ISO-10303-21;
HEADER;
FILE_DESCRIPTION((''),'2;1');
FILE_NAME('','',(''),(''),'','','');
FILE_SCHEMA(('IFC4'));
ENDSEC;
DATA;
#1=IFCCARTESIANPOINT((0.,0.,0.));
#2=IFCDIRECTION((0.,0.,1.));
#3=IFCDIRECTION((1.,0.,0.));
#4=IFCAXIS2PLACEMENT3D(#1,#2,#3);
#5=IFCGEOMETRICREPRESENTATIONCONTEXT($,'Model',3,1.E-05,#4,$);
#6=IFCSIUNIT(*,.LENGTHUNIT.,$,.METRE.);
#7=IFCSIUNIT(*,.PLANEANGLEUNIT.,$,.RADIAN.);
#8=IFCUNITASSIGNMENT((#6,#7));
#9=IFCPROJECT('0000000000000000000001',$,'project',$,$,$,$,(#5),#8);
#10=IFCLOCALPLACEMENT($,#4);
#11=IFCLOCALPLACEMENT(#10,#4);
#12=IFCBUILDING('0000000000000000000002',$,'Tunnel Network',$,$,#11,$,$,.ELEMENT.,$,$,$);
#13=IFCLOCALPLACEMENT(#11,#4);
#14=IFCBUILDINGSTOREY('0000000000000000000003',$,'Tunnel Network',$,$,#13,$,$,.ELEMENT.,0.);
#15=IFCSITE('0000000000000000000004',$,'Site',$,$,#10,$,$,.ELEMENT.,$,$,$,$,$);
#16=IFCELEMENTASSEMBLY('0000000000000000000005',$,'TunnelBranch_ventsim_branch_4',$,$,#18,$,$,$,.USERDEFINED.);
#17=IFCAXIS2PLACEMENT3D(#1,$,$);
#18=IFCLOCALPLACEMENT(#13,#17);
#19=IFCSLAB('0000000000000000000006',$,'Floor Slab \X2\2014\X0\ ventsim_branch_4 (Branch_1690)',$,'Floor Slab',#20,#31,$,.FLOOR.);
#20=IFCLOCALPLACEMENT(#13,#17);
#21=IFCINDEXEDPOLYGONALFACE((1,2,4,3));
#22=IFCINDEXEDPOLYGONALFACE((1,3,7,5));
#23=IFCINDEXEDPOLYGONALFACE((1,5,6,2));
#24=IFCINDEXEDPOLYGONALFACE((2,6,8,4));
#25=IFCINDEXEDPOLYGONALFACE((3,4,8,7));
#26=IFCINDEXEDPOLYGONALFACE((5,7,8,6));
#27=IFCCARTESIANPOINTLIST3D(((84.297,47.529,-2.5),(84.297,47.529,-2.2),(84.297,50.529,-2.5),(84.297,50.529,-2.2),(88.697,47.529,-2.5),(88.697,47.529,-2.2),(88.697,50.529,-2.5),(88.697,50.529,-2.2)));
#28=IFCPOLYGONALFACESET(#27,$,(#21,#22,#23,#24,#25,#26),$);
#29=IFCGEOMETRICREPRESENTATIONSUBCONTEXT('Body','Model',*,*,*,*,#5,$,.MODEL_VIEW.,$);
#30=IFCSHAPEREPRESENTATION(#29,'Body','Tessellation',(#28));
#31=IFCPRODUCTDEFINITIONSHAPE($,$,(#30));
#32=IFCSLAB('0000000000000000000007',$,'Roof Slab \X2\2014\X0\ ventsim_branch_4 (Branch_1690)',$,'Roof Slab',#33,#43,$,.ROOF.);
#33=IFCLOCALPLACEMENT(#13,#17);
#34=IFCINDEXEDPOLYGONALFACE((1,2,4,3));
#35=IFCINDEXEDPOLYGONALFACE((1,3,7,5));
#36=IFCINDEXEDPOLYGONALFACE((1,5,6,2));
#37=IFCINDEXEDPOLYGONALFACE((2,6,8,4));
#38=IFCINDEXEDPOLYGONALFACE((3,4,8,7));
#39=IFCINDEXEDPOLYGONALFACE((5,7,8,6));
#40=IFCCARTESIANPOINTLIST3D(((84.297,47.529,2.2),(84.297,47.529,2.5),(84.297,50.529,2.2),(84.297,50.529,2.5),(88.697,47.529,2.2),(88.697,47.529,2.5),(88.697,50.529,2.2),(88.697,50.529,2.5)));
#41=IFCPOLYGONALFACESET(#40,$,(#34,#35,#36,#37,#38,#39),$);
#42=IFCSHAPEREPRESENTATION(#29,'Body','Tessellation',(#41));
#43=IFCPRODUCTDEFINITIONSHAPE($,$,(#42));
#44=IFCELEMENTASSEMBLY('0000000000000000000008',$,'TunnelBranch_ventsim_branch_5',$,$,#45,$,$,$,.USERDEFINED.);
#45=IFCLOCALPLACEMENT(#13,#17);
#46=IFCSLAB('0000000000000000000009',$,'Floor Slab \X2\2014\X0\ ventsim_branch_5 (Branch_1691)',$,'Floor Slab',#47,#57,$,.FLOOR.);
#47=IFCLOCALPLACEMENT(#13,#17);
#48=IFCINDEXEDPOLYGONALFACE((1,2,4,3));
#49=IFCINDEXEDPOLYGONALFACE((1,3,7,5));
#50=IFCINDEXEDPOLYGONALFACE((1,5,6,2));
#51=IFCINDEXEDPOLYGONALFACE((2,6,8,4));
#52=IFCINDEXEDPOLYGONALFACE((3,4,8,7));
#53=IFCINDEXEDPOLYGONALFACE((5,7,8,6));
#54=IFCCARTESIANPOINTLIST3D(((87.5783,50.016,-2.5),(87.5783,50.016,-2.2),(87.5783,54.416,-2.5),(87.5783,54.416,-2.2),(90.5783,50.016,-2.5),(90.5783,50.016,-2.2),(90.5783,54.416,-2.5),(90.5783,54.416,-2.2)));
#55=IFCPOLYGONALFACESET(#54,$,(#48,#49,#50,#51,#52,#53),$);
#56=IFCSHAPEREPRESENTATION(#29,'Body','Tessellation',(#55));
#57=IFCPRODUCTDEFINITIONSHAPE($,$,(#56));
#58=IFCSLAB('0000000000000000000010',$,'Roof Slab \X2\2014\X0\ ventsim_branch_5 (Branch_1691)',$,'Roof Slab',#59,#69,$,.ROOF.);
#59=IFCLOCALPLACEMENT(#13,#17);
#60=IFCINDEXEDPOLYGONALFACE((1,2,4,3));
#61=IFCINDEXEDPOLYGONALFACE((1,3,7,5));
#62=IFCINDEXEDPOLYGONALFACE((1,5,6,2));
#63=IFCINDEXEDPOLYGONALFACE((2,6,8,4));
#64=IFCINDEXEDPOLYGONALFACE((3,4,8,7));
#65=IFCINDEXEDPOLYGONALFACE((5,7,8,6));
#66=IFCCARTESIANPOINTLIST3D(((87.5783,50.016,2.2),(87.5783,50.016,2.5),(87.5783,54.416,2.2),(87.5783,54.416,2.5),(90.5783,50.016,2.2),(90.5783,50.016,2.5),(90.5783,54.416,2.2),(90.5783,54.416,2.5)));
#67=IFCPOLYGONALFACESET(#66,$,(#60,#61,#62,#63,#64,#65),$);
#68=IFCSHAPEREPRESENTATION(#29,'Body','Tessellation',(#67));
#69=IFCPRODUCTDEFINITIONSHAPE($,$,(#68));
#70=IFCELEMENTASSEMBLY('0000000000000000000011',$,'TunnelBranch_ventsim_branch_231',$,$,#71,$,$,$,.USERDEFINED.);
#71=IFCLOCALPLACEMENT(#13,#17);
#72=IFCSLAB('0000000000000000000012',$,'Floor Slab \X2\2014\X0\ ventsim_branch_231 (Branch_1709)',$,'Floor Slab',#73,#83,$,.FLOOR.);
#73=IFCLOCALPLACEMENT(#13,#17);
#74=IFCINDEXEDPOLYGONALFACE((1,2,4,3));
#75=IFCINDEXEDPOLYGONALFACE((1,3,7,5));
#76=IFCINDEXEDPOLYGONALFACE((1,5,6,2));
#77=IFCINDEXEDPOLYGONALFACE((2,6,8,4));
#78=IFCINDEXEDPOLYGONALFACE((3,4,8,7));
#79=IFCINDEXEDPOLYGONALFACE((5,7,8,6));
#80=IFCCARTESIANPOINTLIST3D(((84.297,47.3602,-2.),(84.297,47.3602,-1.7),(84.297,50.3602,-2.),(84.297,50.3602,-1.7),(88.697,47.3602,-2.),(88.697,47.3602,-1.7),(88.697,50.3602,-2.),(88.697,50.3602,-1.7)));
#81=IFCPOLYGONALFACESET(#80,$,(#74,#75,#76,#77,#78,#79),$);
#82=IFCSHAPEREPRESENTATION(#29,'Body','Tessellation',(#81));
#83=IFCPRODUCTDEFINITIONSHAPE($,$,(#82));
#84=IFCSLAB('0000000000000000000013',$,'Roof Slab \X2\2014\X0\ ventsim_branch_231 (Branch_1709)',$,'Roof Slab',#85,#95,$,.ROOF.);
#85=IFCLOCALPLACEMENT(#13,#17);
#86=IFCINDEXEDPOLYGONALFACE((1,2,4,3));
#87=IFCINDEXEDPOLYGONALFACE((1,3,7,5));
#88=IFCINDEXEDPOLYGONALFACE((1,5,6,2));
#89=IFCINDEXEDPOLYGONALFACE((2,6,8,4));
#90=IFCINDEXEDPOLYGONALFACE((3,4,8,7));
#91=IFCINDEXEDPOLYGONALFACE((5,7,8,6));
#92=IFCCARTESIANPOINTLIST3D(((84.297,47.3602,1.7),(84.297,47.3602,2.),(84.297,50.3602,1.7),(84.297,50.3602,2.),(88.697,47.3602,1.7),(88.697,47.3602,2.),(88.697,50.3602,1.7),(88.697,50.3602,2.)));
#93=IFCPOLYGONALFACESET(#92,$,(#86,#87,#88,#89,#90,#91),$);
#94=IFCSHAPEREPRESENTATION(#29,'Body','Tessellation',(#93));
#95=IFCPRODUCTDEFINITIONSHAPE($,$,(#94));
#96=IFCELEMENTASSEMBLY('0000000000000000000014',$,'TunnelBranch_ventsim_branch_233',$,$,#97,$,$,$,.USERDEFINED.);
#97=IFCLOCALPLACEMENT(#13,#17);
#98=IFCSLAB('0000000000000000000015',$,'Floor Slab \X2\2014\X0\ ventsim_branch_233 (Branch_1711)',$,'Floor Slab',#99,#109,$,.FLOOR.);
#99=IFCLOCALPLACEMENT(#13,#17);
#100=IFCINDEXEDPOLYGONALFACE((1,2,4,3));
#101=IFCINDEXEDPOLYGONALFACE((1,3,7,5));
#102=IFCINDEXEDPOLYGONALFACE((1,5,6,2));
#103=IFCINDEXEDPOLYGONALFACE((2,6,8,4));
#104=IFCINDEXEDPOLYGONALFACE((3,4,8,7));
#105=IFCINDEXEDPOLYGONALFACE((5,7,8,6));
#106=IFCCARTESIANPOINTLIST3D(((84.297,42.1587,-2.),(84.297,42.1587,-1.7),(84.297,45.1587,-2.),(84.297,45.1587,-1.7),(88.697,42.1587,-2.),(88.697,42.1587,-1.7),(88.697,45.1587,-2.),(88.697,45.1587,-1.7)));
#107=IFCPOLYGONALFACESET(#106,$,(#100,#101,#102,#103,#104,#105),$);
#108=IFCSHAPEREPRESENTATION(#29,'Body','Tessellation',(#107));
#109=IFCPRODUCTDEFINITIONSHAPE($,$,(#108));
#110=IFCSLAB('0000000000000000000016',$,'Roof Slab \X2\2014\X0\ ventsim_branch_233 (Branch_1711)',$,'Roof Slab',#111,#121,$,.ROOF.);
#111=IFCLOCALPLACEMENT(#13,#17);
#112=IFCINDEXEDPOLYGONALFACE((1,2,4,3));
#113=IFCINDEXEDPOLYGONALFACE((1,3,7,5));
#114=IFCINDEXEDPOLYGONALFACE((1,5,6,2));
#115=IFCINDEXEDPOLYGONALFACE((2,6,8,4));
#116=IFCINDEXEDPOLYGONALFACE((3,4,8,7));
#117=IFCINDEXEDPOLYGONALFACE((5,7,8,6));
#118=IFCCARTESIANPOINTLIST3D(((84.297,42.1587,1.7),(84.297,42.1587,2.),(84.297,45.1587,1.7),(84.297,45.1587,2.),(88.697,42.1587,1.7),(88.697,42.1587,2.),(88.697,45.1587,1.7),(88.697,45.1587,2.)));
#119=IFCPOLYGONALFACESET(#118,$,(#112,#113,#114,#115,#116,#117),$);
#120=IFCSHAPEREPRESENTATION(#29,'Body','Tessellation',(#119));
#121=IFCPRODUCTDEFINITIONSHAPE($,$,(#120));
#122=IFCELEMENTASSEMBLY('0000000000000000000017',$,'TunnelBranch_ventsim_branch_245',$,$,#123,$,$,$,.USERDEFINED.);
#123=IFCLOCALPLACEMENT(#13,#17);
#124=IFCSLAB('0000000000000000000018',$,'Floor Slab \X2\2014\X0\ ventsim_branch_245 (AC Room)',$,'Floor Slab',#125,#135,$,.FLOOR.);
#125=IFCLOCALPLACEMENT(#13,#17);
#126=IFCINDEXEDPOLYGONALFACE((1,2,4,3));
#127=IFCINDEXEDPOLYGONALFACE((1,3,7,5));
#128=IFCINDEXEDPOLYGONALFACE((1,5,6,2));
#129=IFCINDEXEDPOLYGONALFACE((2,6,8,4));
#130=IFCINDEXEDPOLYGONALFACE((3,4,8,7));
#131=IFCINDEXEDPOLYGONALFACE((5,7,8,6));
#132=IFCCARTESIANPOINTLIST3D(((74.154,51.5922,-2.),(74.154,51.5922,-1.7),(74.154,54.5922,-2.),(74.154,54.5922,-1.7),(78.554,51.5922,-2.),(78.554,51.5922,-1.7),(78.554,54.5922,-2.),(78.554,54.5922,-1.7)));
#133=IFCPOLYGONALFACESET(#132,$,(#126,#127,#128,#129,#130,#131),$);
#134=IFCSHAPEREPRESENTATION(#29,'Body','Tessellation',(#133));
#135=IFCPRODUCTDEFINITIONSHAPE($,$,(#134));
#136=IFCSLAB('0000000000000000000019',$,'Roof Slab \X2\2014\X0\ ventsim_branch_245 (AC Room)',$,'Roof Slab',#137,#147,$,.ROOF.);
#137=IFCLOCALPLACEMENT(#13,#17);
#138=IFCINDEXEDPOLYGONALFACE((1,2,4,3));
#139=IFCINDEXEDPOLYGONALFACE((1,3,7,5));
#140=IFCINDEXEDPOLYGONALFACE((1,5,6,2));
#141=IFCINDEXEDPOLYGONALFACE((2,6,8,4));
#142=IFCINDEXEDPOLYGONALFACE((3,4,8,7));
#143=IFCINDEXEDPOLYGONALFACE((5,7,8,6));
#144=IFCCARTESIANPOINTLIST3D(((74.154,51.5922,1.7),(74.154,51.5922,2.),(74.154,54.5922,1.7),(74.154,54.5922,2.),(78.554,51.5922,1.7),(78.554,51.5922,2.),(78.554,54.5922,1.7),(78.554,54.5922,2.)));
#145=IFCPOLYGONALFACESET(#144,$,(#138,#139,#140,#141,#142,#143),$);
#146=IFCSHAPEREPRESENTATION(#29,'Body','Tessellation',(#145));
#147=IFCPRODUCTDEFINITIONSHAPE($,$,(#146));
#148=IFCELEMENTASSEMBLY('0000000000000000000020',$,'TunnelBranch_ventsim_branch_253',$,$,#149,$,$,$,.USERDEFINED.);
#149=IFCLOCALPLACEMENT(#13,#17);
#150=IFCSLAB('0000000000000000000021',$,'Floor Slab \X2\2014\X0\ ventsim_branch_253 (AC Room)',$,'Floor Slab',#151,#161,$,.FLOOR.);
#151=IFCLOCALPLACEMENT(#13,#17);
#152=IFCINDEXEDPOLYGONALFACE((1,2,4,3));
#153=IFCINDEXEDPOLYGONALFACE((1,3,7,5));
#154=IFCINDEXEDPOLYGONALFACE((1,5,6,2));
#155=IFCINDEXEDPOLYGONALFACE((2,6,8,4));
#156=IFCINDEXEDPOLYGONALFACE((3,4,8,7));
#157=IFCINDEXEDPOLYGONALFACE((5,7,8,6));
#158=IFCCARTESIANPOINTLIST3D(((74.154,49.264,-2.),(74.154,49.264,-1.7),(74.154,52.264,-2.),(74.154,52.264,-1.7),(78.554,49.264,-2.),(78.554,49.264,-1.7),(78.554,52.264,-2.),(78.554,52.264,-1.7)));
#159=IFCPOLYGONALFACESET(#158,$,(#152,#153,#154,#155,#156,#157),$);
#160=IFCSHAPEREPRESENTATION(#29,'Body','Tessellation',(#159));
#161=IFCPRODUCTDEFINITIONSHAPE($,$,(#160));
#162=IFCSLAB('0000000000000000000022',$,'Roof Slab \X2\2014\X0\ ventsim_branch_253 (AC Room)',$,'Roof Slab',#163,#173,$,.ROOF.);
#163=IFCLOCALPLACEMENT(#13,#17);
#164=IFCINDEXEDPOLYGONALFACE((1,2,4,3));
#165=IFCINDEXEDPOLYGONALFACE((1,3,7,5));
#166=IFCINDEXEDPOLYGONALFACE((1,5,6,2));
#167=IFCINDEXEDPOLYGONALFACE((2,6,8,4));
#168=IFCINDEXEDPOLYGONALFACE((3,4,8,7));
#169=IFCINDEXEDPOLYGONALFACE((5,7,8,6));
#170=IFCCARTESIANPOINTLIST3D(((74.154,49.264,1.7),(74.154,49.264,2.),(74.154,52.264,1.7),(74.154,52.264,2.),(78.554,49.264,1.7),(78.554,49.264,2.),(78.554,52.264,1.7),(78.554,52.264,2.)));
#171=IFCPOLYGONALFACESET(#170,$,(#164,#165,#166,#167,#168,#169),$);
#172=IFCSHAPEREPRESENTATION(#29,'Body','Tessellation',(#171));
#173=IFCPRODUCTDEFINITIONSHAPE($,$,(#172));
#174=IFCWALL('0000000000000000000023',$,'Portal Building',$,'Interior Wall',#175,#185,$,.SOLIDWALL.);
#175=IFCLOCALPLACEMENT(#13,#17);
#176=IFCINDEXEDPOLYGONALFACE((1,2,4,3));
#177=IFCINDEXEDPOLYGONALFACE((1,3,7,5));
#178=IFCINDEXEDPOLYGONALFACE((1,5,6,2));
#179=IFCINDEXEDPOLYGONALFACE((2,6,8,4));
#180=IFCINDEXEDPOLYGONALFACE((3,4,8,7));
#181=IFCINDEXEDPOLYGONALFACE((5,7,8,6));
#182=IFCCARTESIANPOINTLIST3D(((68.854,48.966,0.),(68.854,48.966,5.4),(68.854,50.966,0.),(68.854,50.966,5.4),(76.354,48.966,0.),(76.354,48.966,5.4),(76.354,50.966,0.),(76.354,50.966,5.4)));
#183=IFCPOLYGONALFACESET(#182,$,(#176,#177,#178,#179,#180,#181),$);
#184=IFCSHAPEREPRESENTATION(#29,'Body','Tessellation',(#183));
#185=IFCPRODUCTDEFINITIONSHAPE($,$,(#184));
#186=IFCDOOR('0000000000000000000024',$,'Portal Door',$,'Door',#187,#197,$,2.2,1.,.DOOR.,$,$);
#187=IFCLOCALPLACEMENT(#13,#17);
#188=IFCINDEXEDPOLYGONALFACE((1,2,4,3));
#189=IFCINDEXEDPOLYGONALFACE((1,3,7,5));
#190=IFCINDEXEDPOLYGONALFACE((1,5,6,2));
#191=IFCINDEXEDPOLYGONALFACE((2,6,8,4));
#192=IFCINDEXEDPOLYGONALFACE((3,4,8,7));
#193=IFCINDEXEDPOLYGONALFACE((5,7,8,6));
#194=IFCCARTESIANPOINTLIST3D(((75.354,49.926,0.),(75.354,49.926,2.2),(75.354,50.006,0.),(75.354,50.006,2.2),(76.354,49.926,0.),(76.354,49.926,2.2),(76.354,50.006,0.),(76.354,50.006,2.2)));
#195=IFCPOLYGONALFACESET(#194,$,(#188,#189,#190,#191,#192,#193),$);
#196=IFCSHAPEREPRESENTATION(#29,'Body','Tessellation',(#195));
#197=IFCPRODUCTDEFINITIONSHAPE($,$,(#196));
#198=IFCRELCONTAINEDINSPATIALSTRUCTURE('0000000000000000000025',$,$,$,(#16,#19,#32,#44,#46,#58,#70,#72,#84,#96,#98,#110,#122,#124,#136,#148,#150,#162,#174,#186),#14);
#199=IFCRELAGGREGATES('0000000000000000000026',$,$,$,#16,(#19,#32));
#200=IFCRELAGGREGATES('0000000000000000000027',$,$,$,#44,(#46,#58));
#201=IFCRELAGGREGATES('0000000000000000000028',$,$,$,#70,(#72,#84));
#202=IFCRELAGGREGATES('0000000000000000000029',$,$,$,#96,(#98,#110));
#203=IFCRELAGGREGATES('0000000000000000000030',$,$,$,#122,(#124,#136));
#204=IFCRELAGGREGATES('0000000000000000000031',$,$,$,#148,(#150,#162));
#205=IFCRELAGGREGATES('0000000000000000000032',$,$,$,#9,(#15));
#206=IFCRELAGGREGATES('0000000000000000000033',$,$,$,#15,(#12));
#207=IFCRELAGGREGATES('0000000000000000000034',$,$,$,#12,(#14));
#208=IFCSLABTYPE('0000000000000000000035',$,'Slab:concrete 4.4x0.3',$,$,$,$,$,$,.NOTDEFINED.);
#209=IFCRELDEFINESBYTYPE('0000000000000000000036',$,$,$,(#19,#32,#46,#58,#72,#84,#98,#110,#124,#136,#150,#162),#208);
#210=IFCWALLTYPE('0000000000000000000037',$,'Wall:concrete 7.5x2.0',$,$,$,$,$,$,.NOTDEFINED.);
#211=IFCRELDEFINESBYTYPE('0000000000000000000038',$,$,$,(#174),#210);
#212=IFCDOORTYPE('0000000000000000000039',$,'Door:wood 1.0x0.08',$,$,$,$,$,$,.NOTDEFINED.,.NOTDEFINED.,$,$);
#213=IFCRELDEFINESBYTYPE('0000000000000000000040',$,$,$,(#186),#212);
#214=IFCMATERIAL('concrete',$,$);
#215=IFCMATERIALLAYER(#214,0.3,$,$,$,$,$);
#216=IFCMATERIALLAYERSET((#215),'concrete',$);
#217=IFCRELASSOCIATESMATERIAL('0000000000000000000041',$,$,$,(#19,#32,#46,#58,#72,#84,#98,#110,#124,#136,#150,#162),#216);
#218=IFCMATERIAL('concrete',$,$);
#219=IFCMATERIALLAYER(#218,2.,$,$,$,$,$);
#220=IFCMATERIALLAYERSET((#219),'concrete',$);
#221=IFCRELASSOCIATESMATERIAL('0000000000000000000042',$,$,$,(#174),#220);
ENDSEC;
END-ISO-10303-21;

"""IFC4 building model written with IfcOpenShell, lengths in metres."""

from ifc_helpers import new_model, si_unit, frame, origin_with_axes, origin_2d_with_axis, place, context, subcontext, project, spatial, rectangle, extrude, material, layer, layer_set, layer_usage, type_object, element, aggregate, save


model = new_model("IFC4")

# Units and contexts
model_context = context("Model", 3, precision=1e-05, world=origin_with_axes())
body_context = subcontext(model_context, "Body", "Model", "MODEL_VIEW")
ifc_project = project(units=[si_unit("LENGTHUNIT", "METRE"), si_unit("PLANEANGLEUNIT", "RADIAN")], contexts=[model_context])

# Site, building, storey
site_placement = place(None, origin_with_axes())
site = spatial("IfcSite", under=ifc_project, at=site_placement, Name="Site", CompositionType="ELEMENT")
building_placement = place(site_placement, origin_with_axes())
building = spatial("IfcBuilding", under=site, at=building_placement, Name="Tunnel Network", CompositionType="ELEMENT")
storey_placement = place(building_placement, origin_with_axes())
storey = spatial("IfcBuildingStorey", under=building, at=storey_placement, Name="Tunnel Network", CompositionType="ELEMENT", Elevation=0.0)

# Element assemblies, slabs
assembly_1_placement = place(storey_placement, frame((84.147, 47.7701, 0.0), z_axis=(0.0, 1.0, 0.0), x_axis=(1.0, 0.0, 0.0)))
assembly_1 = element("IfcElementAssembly", 1, at=assembly_1_placement, inside=storey, Name="TunnelBranch_ventsim_branch_4", PredefinedType="USERDEFINED")
ifc_material_1 = material(Name="concrete")
ifc_layer_1 = layer(ifc_material_1, 0.3)
ifc_layer_set_1 = layer_set([ifc_layer_1], Name="concrete")
ifc_layer_usage_1 = layer_usage(ifc_layer_set_1, "AXIS3", "POSITIVE", 0.0)
slab_type = type_object("IfcSlabType", Name="Slab:concrete 4.4x0.3")
slab_1_placement = place(storey_placement, frame((86.497, 47.529, -2.35), z_axis=(0.0, 1.0, 0.0), x_axis=(1.0, 0.0, 0.0)))
slab_1 = element("IfcSlab", 2, at=slab_1_placement, inside=storey, type_object=slab_type, material=ifc_layer_usage_1, Name="Floor Slab — ventsim_branch_4 (Branch_1690)", ObjectType="Floor Slab", PredefinedType="FLOOR", context=body_context, shape_type="SweptSolid", body=[
    extrude(rectangle(XDim=4.4, YDim=0.3, at=origin_2d_with_axis()), origin_with_axes(), (0.0, 0.0, 1.0), 3.0),
])
ifc_layer_usage_2 = layer_usage(ifc_layer_set_1, "AXIS3", "POSITIVE", 0.0)
slab_2_placement = place(storey_placement, frame((86.497, 47.529, 2.35), z_axis=(0.0, 1.0, 0.0), x_axis=(1.0, 0.0, 0.0)))
slab_2 = element("IfcSlab", 3, at=slab_2_placement, inside=storey, type_object=slab_type, material=ifc_layer_usage_2, Name="Roof Slab — ventsim_branch_4 (Branch_1690)", ObjectType="Roof Slab", PredefinedType="ROOF", context=body_context, shape_type="SweptSolid", body=[
    extrude(rectangle(XDim=4.4, YDim=0.3, at=origin_2d_with_axis()), origin_with_axes(), (0.0, 0.0, 1.0), 3.0),
])
assembly_2_placement = place(storey_placement, frame((91.0006, 49.866, 0.0), z_axis=(-1.0, 0.0, 0.0), x_axis=(0.0, 1.0, 0.0)))
assembly_2 = element("IfcElementAssembly", 4, at=assembly_2_placement, inside=storey, Name="TunnelBranch_ventsim_branch_5", PredefinedType="USERDEFINED")
ifc_layer_usage_3 = layer_usage(ifc_layer_set_1, "AXIS3", "POSITIVE", 0.0)
slab_3_placement = place(storey_placement, frame((90.5783, 52.216, -2.35), z_axis=(-1.0, 0.0, 0.0), x_axis=(0.0, 1.0, 0.0)))
slab_3 = element("IfcSlab", 5, at=slab_3_placement, inside=storey, type_object=slab_type, material=ifc_layer_usage_3, Name="Floor Slab — ventsim_branch_5 (Branch_1691)", ObjectType="Floor Slab", PredefinedType="FLOOR", context=body_context, shape_type="SweptSolid", body=[
    extrude(rectangle(XDim=4.4, YDim=0.3, at=origin_2d_with_axis()), origin_with_axes(), (0.0, 0.0, 1.0), 3.0),
])
ifc_layer_usage_4 = layer_usage(ifc_layer_set_1, "AXIS3", "POSITIVE", 0.0)
slab_4_placement = place(storey_placement, frame((90.5783, 52.216, 2.35), z_axis=(-1.0, 0.0, 0.0), x_axis=(0.0, 1.0, 0.0)))
slab_4 = element("IfcSlab", 6, at=slab_4_placement, inside=storey, type_object=slab_type, material=ifc_layer_usage_4, Name="Roof Slab — ventsim_branch_5 (Branch_1691)", ObjectType="Roof Slab", PredefinedType="ROOF", context=body_context, shape_type="SweptSolid", body=[
    extrude(rectangle(XDim=4.4, YDim=0.3, at=origin_2d_with_axis()), origin_with_axes(), (0.0, 0.0, 1.0), 3.0),
])
assembly_3_placement = place(storey_placement, frame((84.147, 47.7701, 0.0), z_axis=(0.0, 1.0, 0.0), x_axis=(1.0, 0.0, 0.0)))
assembly_3 = element("IfcElementAssembly", 7, at=assembly_3_placement, inside=storey, Name="TunnelBranch_ventsim_branch_231", PredefinedType="USERDEFINED")
ifc_layer_usage_5 = layer_usage(ifc_layer_set_1, "AXIS3", "POSITIVE", 0.0)
slab_5_placement = place(storey_placement, frame((86.497, 47.3602, -1.85), z_axis=(0.0, 1.0, 0.0), x_axis=(1.0, 0.0, 0.0)))
slab_5 = element("IfcSlab", 8, at=slab_5_placement, inside=storey, type_object=slab_type, material=ifc_layer_usage_5, Name="Floor Slab — ventsim_branch_231 (Branch_1709)", ObjectType="Floor Slab", PredefinedType="FLOOR", context=body_context, shape_type="SweptSolid", body=[
    extrude(rectangle(XDim=4.4, YDim=0.3, at=origin_2d_with_axis()), origin_with_axes(), (0.0, 0.0, 1.0), 3.0),
])
ifc_layer_usage_6 = layer_usage(ifc_layer_set_1, "AXIS3", "POSITIVE", 0.0)
slab_6_placement = place(storey_placement, frame((86.497, 47.3602, 1.85), z_axis=(0.0, 1.0, 0.0), x_axis=(1.0, 0.0, 0.0)))
slab_6 = element("IfcSlab", 9, at=slab_6_placement, inside=storey, type_object=slab_type, material=ifc_layer_usage_6, Name="Roof Slab — ventsim_branch_231 (Branch_1709)", ObjectType="Roof Slab", PredefinedType="ROOF", context=body_context, shape_type="SweptSolid", body=[
    extrude(rectangle(XDim=4.4, YDim=0.3, at=origin_2d_with_axis()), origin_with_axes(), (0.0, 0.0, 1.0), 3.0),
])
assembly_4_placement = place(storey_placement, frame((84.147, 52.3609, 0.0), z_axis=(0.0, 1.0, 0.0), x_axis=(1.0, 0.0, 0.0)))
assembly_4 = element("IfcElementAssembly", 10, at=assembly_4_placement, inside=storey, Name="TunnelBranch_ventsim_branch_233", PredefinedType="USERDEFINED")
ifc_layer_usage_7 = layer_usage(ifc_layer_set_1, "AXIS3", "POSITIVE", 0.0)
slab_7_placement = place(storey_placement, frame((86.497, 42.1587, -1.85), z_axis=(0.0, 1.0, 0.0), x_axis=(1.0, 0.0, 0.0)))
slab_7 = element("IfcSlab", 11, at=slab_7_placement, inside=storey, type_object=slab_type, material=ifc_layer_usage_7, Name="Floor Slab — ventsim_branch_233 (Branch_1711)", ObjectType="Floor Slab", PredefinedType="FLOOR", context=body_context, shape_type="SweptSolid", body=[
    extrude(rectangle(XDim=4.4, YDim=0.3, at=origin_2d_with_axis()), origin_with_axes(), (0.0, 0.0, 1.0), 3.0),
])
ifc_layer_usage_8 = layer_usage(ifc_layer_set_1, "AXIS3", "POSITIVE", 0.0)
slab_8_placement = place(storey_placement, frame((86.497, 42.1587, 1.85), z_axis=(0.0, 1.0, 0.0), x_axis=(1.0, 0.0, 0.0)))
slab_8 = element("IfcSlab", 12, at=slab_8_placement, inside=storey, type_object=slab_type, material=ifc_layer_usage_8, Name="Roof Slab — ventsim_branch_233 (Branch_1711)", ObjectType="Roof Slab", PredefinedType="ROOF", context=body_context, shape_type="SweptSolid", body=[
    extrude(rectangle(XDim=4.4, YDim=0.3, at=origin_2d_with_axis()), origin_with_axes(), (0.0, 0.0, 1.0), 3.0),
])
assembly_5_placement = place(storey_placement, frame((74.004, 51.5922, 0.0), z_axis=(0.0, 1.0, 0.0), x_axis=(1.0, 0.0, 0.0)))
assembly_5 = element("IfcElementAssembly", 13, at=assembly_5_placement, inside=storey, Name="TunnelBranch_ventsim_branch_245", PredefinedType="USERDEFINED")
ifc_layer_usage_9 = layer_usage(ifc_layer_set_1, "AXIS3", "POSITIVE", 0.0)
slab_9_placement = place(storey_placement, frame((76.354, 51.5922, -1.85), z_axis=(0.0, 1.0, 0.0), x_axis=(1.0, 0.0, 0.0)))
slab_9 = element("IfcSlab", 14, at=slab_9_placement, inside=storey, type_object=slab_type, material=ifc_layer_usage_9, Name="Floor Slab — ventsim_branch_245 (AC Room)", ObjectType="Floor Slab", PredefinedType="FLOOR", context=body_context, shape_type="SweptSolid", body=[
    extrude(rectangle(XDim=4.4, YDim=0.3, at=origin_2d_with_axis()), origin_with_axes(), (0.0, 0.0, 1.0), 3.0),
])
ifc_layer_usage_10 = layer_usage(ifc_layer_set_1, "AXIS3", "POSITIVE", 0.0)
slab_10_placement = place(storey_placement, frame((76.354, 51.5922, 1.85), z_axis=(0.0, 1.0, 0.0), x_axis=(1.0, 0.0, 0.0)))
slab_10 = element("IfcSlab", 15, at=slab_10_placement, inside=storey, type_object=slab_type, material=ifc_layer_usage_10, Name="Roof Slab — ventsim_branch_245 (AC Room)", ObjectType="Roof Slab", PredefinedType="ROOF", context=body_context, shape_type="SweptSolid", body=[
    extrude(rectangle(XDim=4.4, YDim=0.3, at=origin_2d_with_axis()), origin_with_axes(), (0.0, 0.0, 1.0), 3.0),
])
assembly_6_placement = place(storey_placement, frame((74.004, 49.264, 0.0), z_axis=(0.0, 1.0, 0.0), x_axis=(1.0, 0.0, 0.0)))
assembly_6 = element("IfcElementAssembly", 16, at=assembly_6_placement, inside=storey, Name="TunnelBranch_ventsim_branch_253", PredefinedType="USERDEFINED")
ifc_layer_usage_11 = layer_usage(ifc_layer_set_1, "AXIS3", "POSITIVE", 0.0)
slab_11_placement = place(storey_placement, frame((76.354, 49.264, -1.85), z_axis=(0.0, 1.0, 0.0), x_axis=(1.0, 0.0, 0.0)))
slab_11 = element("IfcSlab", 17, at=slab_11_placement, inside=storey, type_object=slab_type, material=ifc_layer_usage_11, Name="Floor Slab — ventsim_branch_253 (AC Room)", ObjectType="Floor Slab", PredefinedType="FLOOR", context=body_context, shape_type="SweptSolid", body=[
    extrude(rectangle(XDim=4.4, YDim=0.3, at=origin_2d_with_axis()), origin_with_axes(), (0.0, 0.0, 1.0), 3.0),
])
ifc_layer_usage_12 = layer_usage(ifc_layer_set_1, "AXIS3", "POSITIVE", 0.0)
slab_12_placement = place(storey_placement, frame((76.354, 49.264, 1.85), z_axis=(0.0, 1.0, 0.0), x_axis=(1.0, 0.0, 0.0)))
slab_12 = element("IfcSlab", 18, at=slab_12_placement, inside=storey, type_object=slab_type, material=ifc_layer_usage_12, Name="Roof Slab — ventsim_branch_253 (AC Room)", ObjectType="Roof Slab", PredefinedType="ROOF", context=body_context, shape_type="SweptSolid", body=[
    extrude(rectangle(XDim=4.4, YDim=0.3, at=origin_2d_with_axis()), origin_with_axes(), (0.0, 0.0, 1.0), 3.0),
])

# Wall
ifc_material_2 = material(Name="concrete")
ifc_layer_2 = layer(ifc_material_2, 2.0)
ifc_layer_set_2 = layer_set([ifc_layer_2], Name="concrete")
ifc_layer_usage_13 = layer_usage(ifc_layer_set_2, "AXIS2", "POSITIVE", 0.0)
wall_type_1 = type_object("IfcWallType", Name="Wall:concrete 7.5x2.0")
wall_1_placement = place(storey_placement, frame((72.604, 49.966, 0.0), z_axis=(0.0, 0.0, 1.0), x_axis=(1.0, 0.0, 0.0)))
element("IfcWall", 19, at=wall_1_placement, inside=storey, type_object=wall_type_1, material=ifc_layer_usage_13, Name="Portal Building", ObjectType="Interior Wall", PredefinedType="SOLIDWALL", context=body_context, shape_type="SweptSolid", body=[
    extrude(rectangle(XDim=7.5, YDim=2.0, at=origin_2d_with_axis()), origin_with_axes(), (0.0, 0.0, 1.0), 5.4),
])

# Door
door_type = type_object("IfcDoorType", Name="Door:wood 1.0x0.08")
door_placement = place(storey_placement, frame((75.854, 49.966, 0.0), z_axis=(0.0, 0.0, 1.0), x_axis=(1.0, 0.0, 0.0)))
element("IfcDoor", 20, at=door_placement, inside=storey, type_object=door_type, Name="Portal Door", ObjectType="Door", OverallHeight=2.2, OverallWidth=1.0, PredefinedType="DOOR", context=body_context, shape_type="SweptSolid", body=[
    extrude(rectangle(XDim=1.0, YDim=0.08, at=origin_2d_with_axis()), origin_with_axes(), (0.0, 0.0, 1.0), 2.2),
])

aggregate(assembly_1, [slab_1, slab_2])
aggregate(assembly_2, [slab_3, slab_4])

aggregate(assembly_3, [slab_5, slab_6])
aggregate(assembly_4, [slab_7, slab_8])
aggregate(assembly_5, [slab_9, slab_10])
aggregate(assembly_6, [slab_11, slab_12])

save(model, "model.ifc")
